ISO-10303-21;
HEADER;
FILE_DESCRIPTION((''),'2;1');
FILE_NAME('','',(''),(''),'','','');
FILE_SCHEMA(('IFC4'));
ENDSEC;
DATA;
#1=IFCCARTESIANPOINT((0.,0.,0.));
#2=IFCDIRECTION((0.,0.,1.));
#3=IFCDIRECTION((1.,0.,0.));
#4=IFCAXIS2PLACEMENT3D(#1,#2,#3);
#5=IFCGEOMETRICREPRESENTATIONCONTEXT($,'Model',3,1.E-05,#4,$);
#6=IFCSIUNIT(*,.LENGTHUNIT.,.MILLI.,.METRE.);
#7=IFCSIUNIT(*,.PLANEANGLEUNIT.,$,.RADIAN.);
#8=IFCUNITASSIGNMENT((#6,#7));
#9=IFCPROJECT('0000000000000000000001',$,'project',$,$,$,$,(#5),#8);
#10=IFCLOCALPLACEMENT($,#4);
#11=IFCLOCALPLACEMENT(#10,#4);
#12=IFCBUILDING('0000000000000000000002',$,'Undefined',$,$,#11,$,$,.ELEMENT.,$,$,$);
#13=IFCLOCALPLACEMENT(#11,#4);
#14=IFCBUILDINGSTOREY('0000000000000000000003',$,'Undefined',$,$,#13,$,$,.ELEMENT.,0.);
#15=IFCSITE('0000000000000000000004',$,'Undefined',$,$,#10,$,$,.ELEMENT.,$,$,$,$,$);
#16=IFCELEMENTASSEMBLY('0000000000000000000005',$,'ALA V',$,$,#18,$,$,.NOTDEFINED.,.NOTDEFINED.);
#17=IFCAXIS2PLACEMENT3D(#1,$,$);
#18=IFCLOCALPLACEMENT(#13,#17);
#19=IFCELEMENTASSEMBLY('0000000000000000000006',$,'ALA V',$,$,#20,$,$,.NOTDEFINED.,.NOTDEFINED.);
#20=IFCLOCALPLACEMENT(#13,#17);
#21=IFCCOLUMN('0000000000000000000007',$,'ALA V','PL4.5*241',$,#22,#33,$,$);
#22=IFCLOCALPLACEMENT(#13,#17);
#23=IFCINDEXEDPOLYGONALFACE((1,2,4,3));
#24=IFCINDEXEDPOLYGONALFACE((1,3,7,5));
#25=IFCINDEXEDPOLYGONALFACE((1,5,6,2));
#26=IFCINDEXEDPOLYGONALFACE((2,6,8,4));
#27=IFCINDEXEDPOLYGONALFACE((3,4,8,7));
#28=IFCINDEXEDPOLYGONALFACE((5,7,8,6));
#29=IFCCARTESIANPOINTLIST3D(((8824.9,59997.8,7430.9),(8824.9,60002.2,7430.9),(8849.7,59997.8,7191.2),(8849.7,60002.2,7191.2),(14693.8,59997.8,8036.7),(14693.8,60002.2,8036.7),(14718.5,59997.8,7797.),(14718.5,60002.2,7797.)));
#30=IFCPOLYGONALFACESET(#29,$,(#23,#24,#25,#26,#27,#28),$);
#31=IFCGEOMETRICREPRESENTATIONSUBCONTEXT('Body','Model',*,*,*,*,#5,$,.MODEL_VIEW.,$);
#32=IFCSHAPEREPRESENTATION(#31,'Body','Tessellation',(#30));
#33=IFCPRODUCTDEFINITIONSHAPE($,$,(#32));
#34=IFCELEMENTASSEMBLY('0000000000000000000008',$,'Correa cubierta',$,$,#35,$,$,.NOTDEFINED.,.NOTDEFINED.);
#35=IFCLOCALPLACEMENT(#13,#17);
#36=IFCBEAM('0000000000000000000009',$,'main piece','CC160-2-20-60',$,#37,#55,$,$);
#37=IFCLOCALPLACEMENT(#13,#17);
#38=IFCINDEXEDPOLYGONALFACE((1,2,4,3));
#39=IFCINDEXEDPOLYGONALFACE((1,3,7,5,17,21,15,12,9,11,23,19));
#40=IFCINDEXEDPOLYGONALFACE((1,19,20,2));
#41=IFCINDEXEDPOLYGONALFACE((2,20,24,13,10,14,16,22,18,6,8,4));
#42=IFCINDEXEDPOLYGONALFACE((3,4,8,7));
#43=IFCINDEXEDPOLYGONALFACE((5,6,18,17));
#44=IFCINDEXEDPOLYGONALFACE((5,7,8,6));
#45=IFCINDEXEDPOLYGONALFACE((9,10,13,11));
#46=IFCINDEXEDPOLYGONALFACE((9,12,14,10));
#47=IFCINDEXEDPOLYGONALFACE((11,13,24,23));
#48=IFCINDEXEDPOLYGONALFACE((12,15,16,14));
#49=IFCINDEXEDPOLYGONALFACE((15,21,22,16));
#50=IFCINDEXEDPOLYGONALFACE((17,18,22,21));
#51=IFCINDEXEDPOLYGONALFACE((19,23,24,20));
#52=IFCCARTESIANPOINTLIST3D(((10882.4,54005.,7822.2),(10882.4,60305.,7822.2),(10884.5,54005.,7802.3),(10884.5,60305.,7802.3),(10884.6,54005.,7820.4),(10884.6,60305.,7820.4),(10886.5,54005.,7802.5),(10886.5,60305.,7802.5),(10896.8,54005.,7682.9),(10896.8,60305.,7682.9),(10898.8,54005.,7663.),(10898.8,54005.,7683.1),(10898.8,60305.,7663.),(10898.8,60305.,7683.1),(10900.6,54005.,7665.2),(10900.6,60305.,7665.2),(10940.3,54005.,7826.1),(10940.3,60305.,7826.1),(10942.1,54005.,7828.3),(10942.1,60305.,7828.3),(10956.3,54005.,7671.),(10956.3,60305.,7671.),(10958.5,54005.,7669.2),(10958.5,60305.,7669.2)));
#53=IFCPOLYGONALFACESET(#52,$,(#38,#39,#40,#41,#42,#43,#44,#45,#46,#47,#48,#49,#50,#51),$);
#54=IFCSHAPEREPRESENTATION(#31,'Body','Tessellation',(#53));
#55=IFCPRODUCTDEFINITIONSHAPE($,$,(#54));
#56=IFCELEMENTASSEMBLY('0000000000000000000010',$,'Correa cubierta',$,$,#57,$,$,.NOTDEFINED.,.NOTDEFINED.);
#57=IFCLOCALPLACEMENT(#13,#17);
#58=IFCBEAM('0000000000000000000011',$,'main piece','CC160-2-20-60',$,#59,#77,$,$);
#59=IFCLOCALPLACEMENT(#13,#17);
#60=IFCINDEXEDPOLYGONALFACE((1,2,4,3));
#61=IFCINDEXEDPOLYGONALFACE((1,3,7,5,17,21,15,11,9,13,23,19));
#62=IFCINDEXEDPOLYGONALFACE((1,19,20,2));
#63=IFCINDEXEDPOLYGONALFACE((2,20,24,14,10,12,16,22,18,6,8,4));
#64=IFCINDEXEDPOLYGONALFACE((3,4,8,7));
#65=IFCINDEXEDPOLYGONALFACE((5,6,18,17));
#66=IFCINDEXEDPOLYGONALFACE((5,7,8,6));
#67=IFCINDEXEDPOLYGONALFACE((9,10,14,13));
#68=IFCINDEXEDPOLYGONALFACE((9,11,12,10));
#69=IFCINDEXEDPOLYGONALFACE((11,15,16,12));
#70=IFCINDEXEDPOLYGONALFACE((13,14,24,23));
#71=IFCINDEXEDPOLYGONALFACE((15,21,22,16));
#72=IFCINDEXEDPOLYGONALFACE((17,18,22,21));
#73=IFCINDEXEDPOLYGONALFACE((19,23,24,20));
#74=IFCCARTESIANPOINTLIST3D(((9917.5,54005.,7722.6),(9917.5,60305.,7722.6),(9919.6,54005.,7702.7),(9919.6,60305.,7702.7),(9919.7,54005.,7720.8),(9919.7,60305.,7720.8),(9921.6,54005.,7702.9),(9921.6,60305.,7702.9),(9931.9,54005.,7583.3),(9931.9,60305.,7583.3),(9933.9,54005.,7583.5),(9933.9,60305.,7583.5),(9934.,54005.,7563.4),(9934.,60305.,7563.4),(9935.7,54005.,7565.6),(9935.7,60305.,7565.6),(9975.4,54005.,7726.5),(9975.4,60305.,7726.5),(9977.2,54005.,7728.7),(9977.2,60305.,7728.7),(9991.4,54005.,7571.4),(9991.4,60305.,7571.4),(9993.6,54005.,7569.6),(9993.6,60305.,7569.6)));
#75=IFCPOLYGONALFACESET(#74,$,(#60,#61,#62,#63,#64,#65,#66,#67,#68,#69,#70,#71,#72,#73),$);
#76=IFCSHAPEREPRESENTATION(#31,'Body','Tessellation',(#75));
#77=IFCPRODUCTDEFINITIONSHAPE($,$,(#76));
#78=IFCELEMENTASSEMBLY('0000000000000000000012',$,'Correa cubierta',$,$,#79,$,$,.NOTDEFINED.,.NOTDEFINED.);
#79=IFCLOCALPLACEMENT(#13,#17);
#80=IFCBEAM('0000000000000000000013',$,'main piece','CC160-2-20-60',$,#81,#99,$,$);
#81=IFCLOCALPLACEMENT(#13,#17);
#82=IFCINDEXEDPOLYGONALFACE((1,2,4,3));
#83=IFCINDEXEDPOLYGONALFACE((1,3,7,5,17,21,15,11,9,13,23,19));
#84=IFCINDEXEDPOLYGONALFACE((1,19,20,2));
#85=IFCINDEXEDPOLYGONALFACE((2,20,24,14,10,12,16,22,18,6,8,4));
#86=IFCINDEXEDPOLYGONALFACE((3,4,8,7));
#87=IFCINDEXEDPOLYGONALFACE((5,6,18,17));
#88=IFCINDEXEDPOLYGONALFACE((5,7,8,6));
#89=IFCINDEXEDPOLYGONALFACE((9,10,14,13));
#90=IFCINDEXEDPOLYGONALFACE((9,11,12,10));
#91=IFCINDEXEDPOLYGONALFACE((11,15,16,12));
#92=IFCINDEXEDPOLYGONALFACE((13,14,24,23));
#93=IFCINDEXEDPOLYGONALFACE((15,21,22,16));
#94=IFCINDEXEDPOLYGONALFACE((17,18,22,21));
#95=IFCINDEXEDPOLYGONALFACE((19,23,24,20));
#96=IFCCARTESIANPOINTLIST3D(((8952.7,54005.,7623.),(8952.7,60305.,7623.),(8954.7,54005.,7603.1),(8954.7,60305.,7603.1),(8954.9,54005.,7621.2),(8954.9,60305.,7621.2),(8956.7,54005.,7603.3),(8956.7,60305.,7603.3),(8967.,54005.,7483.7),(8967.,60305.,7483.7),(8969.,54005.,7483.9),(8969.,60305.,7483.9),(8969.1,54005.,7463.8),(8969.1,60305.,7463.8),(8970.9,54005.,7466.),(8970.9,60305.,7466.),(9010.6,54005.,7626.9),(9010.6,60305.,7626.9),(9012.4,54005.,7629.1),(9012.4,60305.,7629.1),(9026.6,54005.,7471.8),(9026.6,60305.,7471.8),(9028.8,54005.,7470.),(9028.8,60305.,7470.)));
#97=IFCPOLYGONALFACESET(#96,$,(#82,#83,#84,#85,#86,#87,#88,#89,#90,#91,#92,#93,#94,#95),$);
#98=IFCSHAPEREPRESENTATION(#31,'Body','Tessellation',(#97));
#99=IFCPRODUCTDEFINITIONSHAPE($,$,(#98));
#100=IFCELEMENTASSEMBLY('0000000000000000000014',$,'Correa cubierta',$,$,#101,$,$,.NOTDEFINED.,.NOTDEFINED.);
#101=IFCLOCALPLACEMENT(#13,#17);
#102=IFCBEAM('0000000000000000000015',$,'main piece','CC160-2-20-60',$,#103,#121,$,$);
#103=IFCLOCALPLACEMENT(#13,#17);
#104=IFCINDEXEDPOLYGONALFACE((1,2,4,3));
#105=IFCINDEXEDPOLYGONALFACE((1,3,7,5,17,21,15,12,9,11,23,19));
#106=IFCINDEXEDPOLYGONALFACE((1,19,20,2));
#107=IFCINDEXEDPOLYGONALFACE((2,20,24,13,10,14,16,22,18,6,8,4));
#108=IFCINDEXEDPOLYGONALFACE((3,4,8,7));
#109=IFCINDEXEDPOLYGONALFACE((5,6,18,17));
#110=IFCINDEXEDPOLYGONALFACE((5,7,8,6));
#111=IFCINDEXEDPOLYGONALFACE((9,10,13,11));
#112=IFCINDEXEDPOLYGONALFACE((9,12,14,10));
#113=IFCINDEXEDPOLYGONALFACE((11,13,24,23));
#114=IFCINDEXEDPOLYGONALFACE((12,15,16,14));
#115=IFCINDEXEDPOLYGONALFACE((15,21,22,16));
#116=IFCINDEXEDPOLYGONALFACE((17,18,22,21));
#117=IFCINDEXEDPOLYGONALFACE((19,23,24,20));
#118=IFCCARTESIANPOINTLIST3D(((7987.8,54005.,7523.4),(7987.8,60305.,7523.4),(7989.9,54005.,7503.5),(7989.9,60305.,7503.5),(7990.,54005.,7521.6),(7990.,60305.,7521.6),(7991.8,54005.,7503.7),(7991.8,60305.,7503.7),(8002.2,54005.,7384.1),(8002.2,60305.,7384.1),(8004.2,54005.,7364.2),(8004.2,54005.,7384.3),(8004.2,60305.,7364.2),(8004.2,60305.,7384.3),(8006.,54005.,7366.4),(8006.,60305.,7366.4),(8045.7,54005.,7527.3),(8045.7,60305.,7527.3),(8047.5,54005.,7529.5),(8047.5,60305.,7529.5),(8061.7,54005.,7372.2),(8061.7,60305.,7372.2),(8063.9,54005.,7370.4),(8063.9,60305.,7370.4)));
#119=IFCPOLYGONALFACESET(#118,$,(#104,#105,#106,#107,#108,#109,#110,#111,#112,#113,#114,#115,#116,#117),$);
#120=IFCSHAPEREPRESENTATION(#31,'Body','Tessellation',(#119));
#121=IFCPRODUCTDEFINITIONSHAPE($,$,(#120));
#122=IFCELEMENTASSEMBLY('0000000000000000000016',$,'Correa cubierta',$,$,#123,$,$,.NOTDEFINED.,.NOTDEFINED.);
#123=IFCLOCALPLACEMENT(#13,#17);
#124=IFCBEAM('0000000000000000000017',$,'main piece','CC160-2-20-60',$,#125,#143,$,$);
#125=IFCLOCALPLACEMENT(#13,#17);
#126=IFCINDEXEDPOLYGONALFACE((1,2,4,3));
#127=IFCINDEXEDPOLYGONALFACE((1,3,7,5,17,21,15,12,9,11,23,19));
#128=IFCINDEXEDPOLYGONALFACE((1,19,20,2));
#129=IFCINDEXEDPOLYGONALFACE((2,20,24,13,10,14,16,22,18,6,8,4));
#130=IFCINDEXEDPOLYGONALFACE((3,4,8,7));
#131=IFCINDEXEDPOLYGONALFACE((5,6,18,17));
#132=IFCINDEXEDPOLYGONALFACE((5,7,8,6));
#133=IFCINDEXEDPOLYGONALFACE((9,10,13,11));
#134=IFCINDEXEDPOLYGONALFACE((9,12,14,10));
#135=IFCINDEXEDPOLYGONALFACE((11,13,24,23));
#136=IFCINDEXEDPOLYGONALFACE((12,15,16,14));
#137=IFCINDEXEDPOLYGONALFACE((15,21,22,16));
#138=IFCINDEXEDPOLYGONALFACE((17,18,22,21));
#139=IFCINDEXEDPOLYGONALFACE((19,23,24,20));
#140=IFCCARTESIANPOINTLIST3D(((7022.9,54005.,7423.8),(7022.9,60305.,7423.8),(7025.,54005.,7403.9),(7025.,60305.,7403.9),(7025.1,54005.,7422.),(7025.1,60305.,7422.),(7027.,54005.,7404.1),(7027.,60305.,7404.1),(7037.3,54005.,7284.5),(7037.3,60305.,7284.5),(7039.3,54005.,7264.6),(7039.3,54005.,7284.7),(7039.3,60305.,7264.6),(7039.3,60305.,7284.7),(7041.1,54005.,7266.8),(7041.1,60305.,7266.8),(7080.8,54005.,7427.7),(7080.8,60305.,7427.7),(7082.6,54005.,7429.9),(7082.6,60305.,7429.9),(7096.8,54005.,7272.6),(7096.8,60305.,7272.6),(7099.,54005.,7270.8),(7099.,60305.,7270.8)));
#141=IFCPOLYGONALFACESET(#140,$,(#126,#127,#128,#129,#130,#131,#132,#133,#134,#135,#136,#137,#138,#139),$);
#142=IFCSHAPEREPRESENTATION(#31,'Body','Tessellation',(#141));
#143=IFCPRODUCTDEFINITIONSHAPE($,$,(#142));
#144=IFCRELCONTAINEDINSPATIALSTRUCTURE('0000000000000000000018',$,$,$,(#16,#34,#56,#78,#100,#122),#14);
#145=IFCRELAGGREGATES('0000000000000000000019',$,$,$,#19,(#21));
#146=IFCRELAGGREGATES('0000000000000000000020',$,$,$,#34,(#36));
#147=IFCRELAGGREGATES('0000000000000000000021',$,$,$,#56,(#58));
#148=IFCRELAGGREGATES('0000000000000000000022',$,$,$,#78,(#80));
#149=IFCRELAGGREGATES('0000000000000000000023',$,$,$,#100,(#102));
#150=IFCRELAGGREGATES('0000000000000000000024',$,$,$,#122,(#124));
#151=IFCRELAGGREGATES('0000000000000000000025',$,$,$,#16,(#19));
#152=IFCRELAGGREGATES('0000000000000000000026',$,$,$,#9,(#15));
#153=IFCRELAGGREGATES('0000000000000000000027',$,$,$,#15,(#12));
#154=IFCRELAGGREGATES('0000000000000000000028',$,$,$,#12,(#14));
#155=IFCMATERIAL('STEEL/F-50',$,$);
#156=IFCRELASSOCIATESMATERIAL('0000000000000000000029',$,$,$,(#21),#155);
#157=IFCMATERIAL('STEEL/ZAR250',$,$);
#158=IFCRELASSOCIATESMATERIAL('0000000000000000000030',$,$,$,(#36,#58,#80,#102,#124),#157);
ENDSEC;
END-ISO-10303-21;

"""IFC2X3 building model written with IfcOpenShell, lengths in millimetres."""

from ifc_helpers import new_model, si_unit, frame, origin_with_axes, origin_2d_with_axis, place, context, subcontext, project, spatial, rectangle, c_section, extrude, material, element, aggregate, save


model = new_model("IFC2X3")

# Units and contexts
model_context = context("Model", 3, precision=1e-05, world=origin_with_axes())
body_context = subcontext(model_context, "Body", "Model", "MODEL_VIEW")
ifc_project = project(units=[si_unit("LENGTHUNIT", "METRE", prefix="MILLI"), si_unit("PLANEANGLEUNIT", "RADIAN")], contexts=[model_context])

# Site, building, storey
site_placement = place(None, origin_with_axes())
site = spatial("IfcSite", under=ifc_project, at=site_placement, Name="Undefined", CompositionType="ELEMENT")
building_placement = place(site_placement, origin_with_axes())
building = spatial("IfcBuilding", under=site, at=building_placement, Name="Undefined", CompositionType="ELEMENT")
storey_placement = place(building_placement, origin_with_axes())
storey = spatial("IfcBuildingStorey", under=building, at=storey_placement, Name="Undefined", CompositionType="ELEMENT", Elevation=0.0)

# Element assemblies, column
assembly_1_placement = place(storey_placement, origin_with_axes())
assembly_1 = element("IfcElementAssembly", 1, at=assembly_1_placement, inside=storey, Name="ALA V", AssemblyPlace="NOTDEFINED", PredefinedType="NOTDEFINED")
assembly_2_placement = place(assembly_1_placement, origin_with_axes())
assembly_2 = element("IfcElementAssembly", 2, at=assembly_2_placement, Name="ALA V", AssemblyPlace="NOTDEFINED", PredefinedType="NOTDEFINED")
ifc_material_1 = material(Name="STEEL/F-50")
column_placement = place(assembly_2_placement, frame((8837.3, 60000.0, 7311.1), z_axis=(0.994715, 0.0, 0.102675), x_axis=(-0.102676, 0.0, 0.994715)))
column = element("IfcColumn", 3, at=column_placement, material=ifc_material_1, Name="ALA V", Description="PL4.5*241", context=body_context, shape_type="SweptSolid", body=[
    extrude(rectangle(XDim=4.5, YDim=241.0, at=origin_2d_with_axis()), frame((0.0, 0.0, 5900.0), z_axis=(0.0, 0.0, -1.0), x_axis=(0.0, 1.0, 0.0)), (0.0, 0.0, 1.0), 5900.0),
])
aggregate(assembly_2, [column])

# Element assemblies, beams
assembly_3_placement = place(storey_placement, origin_with_axes())
assembly_3 = element("IfcElementAssembly", 4, at=assembly_3_placement, inside=storey, Name="Correa cubierta", AssemblyPlace="NOTDEFINED", PredefinedType="NOTDEFINED")
ifc_material_2 = material(Name="STEEL/ZAR250")
beam_1_placement = place(assembly_3_placement, frame((10920.5, 60305.0, 7745.7), z_axis=(-0.102562, 0.0, 0.994727), x_axis=(0.0, -1.0, 0.0)))
beam_1 = element("IfcBeam", 5, at=beam_1_placement, material=ifc_material_2, Name="main piece", Description="CC160-2-20-60", context=body_context, shape_type="SweptSolid", body=[
    extrude(c_section(Depth=160.0, Width=60.0, WallThickness=2.0, Girth=20.0, at=origin_2d_with_axis()), frame((6300.0, 0.0, 0.0), z_axis=(-1.0, 0.0, 0.0), x_axis=(0.0, -1.0, 0.0)), (0.0, 0.0, 1.0), 6300.0),
])
aggregate(assembly_3, [beam_1])
assembly_4_placement = place(storey_placement, origin_with_axes())
assembly_4 = element("IfcElementAssembly", 6, at=assembly_4_placement, inside=storey, Name="Correa cubierta", AssemblyPlace="NOTDEFINED", PredefinedType="NOTDEFINED")
beam_2_placement = place(assembly_4_placement, frame((9955.6, 60305.0, 7646.1), z_axis=(-0.102562, 0.0, 0.994727), x_axis=(0.0, -1.0, 0.0)))
beam_2 = element("IfcBeam", 7, at=beam_2_placement, material=ifc_material_2, Name="main piece", Description="CC160-2-20-60", context=body_context, shape_type="SweptSolid", body=[
    extrude(c_section(Depth=160.0, Width=60.0, WallThickness=2.0, Girth=20.0, at=origin_2d_with_axis()), frame((6300.0, 0.0, 0.0), z_axis=(-1.0, 0.0, 0.0), x_axis=(0.0, -1.0, 0.0)), (0.0, 0.0, 1.0), 6300.0),
])
aggregate(assembly_4, [beam_2])
assembly_5_placement = place(storey_placement, origin_with_axes())
assembly_5 = element("IfcElementAssembly", 8, at=assembly_5_placement, inside=storey, Name="Correa cubierta", AssemblyPlace="NOTDEFINED", PredefinedType="NOTDEFINED")
beam_3_placement = place(assembly_5_placement, frame((8990.7, 60305.0, 7546.5), z_axis=(-0.102562, 0.0, 0.994727), x_axis=(0.0, -1.0, 0.0)))
beam_3 = element("IfcBeam", 9, at=beam_3_placement, material=ifc_material_2, Name="main piece", Description="CC160-2-20-60", context=body_context, shape_type="SweptSolid", body=[
    extrude(c_section(Depth=160.0, Width=60.0, WallThickness=2.0, Girth=20.0, at=origin_2d_with_axis()), frame((6300.0, 0.0, 0.0), z_axis=(-1.0, 0.0, 0.0), x_axis=(0.0, -1.0, 0.0)), (0.0, 0.0, 1.0), 6300.0),
])
aggregate(assembly_5, [beam_3])
assembly_6_placement = place(storey_placement, origin_with_axes())
assembly_6 = element("IfcElementAssembly", 10, at=assembly_6_placement, inside=storey, Name="Correa cubierta", AssemblyPlace="NOTDEFINED", PredefinedType="NOTDEFINED")
beam_4_placement = place(assembly_6_placement, frame((8025.8, 60305.0, 7446.9), z_axis=(-0.102562, 0.0, 0.994727), x_axis=(0.0, -1.0, 0.0)))
beam_4 = element("IfcBeam", 11, at=beam_4_placement, material=ifc_material_2, Name="main piece", Description="CC160-2-20-60", context=body_context, shape_type="SweptSolid", body=[
    extrude(c_section(Depth=160.0, Width=60.0, WallThickness=2.0, Girth=20.0, at=origin_2d_with_axis()), frame((6300.0, 0.0, 0.0), z_axis=(-1.0, 0.0, 0.0), x_axis=(0.0, -1.0, 0.0)), (0.0, 0.0, 1.0), 6300.0),
])
aggregate(assembly_6, [beam_4])
assembly_7_placement = place(storey_placement, origin_with_axes())
assembly_7 = element("IfcElementAssembly", 12, at=assembly_7_placement, inside=storey, Name="Correa cubierta", AssemblyPlace="NOTDEFINED", PredefinedType="NOTDEFINED")
beam_5_placement = place(assembly_7_placement, frame((7061.0, 60305.0, 7347.3), z_axis=(-0.102562, 0.0, 0.994727), x_axis=(0.0, -1.0, 0.0)))
beam_5 = element("IfcBeam", 13, at=beam_5_placement, material=ifc_material_2, Name="main piece", Description="CC160-2-20-60", context=body_context, shape_type="SweptSolid", body=[
    extrude(c_section(Depth=160.0, Width=60.0, WallThickness=2.0, Girth=20.0, at=origin_2d_with_axis()), frame((6300.0, 0.0, 0.0), z_axis=(-1.0, 0.0, 0.0), x_axis=(0.0, -1.0, 0.0)), (0.0, 0.0, 1.0), 6300.0),
])
aggregate(assembly_7, [beam_5])

aggregate(assembly_1, [assembly_2])

save(model, "model.ifc")
